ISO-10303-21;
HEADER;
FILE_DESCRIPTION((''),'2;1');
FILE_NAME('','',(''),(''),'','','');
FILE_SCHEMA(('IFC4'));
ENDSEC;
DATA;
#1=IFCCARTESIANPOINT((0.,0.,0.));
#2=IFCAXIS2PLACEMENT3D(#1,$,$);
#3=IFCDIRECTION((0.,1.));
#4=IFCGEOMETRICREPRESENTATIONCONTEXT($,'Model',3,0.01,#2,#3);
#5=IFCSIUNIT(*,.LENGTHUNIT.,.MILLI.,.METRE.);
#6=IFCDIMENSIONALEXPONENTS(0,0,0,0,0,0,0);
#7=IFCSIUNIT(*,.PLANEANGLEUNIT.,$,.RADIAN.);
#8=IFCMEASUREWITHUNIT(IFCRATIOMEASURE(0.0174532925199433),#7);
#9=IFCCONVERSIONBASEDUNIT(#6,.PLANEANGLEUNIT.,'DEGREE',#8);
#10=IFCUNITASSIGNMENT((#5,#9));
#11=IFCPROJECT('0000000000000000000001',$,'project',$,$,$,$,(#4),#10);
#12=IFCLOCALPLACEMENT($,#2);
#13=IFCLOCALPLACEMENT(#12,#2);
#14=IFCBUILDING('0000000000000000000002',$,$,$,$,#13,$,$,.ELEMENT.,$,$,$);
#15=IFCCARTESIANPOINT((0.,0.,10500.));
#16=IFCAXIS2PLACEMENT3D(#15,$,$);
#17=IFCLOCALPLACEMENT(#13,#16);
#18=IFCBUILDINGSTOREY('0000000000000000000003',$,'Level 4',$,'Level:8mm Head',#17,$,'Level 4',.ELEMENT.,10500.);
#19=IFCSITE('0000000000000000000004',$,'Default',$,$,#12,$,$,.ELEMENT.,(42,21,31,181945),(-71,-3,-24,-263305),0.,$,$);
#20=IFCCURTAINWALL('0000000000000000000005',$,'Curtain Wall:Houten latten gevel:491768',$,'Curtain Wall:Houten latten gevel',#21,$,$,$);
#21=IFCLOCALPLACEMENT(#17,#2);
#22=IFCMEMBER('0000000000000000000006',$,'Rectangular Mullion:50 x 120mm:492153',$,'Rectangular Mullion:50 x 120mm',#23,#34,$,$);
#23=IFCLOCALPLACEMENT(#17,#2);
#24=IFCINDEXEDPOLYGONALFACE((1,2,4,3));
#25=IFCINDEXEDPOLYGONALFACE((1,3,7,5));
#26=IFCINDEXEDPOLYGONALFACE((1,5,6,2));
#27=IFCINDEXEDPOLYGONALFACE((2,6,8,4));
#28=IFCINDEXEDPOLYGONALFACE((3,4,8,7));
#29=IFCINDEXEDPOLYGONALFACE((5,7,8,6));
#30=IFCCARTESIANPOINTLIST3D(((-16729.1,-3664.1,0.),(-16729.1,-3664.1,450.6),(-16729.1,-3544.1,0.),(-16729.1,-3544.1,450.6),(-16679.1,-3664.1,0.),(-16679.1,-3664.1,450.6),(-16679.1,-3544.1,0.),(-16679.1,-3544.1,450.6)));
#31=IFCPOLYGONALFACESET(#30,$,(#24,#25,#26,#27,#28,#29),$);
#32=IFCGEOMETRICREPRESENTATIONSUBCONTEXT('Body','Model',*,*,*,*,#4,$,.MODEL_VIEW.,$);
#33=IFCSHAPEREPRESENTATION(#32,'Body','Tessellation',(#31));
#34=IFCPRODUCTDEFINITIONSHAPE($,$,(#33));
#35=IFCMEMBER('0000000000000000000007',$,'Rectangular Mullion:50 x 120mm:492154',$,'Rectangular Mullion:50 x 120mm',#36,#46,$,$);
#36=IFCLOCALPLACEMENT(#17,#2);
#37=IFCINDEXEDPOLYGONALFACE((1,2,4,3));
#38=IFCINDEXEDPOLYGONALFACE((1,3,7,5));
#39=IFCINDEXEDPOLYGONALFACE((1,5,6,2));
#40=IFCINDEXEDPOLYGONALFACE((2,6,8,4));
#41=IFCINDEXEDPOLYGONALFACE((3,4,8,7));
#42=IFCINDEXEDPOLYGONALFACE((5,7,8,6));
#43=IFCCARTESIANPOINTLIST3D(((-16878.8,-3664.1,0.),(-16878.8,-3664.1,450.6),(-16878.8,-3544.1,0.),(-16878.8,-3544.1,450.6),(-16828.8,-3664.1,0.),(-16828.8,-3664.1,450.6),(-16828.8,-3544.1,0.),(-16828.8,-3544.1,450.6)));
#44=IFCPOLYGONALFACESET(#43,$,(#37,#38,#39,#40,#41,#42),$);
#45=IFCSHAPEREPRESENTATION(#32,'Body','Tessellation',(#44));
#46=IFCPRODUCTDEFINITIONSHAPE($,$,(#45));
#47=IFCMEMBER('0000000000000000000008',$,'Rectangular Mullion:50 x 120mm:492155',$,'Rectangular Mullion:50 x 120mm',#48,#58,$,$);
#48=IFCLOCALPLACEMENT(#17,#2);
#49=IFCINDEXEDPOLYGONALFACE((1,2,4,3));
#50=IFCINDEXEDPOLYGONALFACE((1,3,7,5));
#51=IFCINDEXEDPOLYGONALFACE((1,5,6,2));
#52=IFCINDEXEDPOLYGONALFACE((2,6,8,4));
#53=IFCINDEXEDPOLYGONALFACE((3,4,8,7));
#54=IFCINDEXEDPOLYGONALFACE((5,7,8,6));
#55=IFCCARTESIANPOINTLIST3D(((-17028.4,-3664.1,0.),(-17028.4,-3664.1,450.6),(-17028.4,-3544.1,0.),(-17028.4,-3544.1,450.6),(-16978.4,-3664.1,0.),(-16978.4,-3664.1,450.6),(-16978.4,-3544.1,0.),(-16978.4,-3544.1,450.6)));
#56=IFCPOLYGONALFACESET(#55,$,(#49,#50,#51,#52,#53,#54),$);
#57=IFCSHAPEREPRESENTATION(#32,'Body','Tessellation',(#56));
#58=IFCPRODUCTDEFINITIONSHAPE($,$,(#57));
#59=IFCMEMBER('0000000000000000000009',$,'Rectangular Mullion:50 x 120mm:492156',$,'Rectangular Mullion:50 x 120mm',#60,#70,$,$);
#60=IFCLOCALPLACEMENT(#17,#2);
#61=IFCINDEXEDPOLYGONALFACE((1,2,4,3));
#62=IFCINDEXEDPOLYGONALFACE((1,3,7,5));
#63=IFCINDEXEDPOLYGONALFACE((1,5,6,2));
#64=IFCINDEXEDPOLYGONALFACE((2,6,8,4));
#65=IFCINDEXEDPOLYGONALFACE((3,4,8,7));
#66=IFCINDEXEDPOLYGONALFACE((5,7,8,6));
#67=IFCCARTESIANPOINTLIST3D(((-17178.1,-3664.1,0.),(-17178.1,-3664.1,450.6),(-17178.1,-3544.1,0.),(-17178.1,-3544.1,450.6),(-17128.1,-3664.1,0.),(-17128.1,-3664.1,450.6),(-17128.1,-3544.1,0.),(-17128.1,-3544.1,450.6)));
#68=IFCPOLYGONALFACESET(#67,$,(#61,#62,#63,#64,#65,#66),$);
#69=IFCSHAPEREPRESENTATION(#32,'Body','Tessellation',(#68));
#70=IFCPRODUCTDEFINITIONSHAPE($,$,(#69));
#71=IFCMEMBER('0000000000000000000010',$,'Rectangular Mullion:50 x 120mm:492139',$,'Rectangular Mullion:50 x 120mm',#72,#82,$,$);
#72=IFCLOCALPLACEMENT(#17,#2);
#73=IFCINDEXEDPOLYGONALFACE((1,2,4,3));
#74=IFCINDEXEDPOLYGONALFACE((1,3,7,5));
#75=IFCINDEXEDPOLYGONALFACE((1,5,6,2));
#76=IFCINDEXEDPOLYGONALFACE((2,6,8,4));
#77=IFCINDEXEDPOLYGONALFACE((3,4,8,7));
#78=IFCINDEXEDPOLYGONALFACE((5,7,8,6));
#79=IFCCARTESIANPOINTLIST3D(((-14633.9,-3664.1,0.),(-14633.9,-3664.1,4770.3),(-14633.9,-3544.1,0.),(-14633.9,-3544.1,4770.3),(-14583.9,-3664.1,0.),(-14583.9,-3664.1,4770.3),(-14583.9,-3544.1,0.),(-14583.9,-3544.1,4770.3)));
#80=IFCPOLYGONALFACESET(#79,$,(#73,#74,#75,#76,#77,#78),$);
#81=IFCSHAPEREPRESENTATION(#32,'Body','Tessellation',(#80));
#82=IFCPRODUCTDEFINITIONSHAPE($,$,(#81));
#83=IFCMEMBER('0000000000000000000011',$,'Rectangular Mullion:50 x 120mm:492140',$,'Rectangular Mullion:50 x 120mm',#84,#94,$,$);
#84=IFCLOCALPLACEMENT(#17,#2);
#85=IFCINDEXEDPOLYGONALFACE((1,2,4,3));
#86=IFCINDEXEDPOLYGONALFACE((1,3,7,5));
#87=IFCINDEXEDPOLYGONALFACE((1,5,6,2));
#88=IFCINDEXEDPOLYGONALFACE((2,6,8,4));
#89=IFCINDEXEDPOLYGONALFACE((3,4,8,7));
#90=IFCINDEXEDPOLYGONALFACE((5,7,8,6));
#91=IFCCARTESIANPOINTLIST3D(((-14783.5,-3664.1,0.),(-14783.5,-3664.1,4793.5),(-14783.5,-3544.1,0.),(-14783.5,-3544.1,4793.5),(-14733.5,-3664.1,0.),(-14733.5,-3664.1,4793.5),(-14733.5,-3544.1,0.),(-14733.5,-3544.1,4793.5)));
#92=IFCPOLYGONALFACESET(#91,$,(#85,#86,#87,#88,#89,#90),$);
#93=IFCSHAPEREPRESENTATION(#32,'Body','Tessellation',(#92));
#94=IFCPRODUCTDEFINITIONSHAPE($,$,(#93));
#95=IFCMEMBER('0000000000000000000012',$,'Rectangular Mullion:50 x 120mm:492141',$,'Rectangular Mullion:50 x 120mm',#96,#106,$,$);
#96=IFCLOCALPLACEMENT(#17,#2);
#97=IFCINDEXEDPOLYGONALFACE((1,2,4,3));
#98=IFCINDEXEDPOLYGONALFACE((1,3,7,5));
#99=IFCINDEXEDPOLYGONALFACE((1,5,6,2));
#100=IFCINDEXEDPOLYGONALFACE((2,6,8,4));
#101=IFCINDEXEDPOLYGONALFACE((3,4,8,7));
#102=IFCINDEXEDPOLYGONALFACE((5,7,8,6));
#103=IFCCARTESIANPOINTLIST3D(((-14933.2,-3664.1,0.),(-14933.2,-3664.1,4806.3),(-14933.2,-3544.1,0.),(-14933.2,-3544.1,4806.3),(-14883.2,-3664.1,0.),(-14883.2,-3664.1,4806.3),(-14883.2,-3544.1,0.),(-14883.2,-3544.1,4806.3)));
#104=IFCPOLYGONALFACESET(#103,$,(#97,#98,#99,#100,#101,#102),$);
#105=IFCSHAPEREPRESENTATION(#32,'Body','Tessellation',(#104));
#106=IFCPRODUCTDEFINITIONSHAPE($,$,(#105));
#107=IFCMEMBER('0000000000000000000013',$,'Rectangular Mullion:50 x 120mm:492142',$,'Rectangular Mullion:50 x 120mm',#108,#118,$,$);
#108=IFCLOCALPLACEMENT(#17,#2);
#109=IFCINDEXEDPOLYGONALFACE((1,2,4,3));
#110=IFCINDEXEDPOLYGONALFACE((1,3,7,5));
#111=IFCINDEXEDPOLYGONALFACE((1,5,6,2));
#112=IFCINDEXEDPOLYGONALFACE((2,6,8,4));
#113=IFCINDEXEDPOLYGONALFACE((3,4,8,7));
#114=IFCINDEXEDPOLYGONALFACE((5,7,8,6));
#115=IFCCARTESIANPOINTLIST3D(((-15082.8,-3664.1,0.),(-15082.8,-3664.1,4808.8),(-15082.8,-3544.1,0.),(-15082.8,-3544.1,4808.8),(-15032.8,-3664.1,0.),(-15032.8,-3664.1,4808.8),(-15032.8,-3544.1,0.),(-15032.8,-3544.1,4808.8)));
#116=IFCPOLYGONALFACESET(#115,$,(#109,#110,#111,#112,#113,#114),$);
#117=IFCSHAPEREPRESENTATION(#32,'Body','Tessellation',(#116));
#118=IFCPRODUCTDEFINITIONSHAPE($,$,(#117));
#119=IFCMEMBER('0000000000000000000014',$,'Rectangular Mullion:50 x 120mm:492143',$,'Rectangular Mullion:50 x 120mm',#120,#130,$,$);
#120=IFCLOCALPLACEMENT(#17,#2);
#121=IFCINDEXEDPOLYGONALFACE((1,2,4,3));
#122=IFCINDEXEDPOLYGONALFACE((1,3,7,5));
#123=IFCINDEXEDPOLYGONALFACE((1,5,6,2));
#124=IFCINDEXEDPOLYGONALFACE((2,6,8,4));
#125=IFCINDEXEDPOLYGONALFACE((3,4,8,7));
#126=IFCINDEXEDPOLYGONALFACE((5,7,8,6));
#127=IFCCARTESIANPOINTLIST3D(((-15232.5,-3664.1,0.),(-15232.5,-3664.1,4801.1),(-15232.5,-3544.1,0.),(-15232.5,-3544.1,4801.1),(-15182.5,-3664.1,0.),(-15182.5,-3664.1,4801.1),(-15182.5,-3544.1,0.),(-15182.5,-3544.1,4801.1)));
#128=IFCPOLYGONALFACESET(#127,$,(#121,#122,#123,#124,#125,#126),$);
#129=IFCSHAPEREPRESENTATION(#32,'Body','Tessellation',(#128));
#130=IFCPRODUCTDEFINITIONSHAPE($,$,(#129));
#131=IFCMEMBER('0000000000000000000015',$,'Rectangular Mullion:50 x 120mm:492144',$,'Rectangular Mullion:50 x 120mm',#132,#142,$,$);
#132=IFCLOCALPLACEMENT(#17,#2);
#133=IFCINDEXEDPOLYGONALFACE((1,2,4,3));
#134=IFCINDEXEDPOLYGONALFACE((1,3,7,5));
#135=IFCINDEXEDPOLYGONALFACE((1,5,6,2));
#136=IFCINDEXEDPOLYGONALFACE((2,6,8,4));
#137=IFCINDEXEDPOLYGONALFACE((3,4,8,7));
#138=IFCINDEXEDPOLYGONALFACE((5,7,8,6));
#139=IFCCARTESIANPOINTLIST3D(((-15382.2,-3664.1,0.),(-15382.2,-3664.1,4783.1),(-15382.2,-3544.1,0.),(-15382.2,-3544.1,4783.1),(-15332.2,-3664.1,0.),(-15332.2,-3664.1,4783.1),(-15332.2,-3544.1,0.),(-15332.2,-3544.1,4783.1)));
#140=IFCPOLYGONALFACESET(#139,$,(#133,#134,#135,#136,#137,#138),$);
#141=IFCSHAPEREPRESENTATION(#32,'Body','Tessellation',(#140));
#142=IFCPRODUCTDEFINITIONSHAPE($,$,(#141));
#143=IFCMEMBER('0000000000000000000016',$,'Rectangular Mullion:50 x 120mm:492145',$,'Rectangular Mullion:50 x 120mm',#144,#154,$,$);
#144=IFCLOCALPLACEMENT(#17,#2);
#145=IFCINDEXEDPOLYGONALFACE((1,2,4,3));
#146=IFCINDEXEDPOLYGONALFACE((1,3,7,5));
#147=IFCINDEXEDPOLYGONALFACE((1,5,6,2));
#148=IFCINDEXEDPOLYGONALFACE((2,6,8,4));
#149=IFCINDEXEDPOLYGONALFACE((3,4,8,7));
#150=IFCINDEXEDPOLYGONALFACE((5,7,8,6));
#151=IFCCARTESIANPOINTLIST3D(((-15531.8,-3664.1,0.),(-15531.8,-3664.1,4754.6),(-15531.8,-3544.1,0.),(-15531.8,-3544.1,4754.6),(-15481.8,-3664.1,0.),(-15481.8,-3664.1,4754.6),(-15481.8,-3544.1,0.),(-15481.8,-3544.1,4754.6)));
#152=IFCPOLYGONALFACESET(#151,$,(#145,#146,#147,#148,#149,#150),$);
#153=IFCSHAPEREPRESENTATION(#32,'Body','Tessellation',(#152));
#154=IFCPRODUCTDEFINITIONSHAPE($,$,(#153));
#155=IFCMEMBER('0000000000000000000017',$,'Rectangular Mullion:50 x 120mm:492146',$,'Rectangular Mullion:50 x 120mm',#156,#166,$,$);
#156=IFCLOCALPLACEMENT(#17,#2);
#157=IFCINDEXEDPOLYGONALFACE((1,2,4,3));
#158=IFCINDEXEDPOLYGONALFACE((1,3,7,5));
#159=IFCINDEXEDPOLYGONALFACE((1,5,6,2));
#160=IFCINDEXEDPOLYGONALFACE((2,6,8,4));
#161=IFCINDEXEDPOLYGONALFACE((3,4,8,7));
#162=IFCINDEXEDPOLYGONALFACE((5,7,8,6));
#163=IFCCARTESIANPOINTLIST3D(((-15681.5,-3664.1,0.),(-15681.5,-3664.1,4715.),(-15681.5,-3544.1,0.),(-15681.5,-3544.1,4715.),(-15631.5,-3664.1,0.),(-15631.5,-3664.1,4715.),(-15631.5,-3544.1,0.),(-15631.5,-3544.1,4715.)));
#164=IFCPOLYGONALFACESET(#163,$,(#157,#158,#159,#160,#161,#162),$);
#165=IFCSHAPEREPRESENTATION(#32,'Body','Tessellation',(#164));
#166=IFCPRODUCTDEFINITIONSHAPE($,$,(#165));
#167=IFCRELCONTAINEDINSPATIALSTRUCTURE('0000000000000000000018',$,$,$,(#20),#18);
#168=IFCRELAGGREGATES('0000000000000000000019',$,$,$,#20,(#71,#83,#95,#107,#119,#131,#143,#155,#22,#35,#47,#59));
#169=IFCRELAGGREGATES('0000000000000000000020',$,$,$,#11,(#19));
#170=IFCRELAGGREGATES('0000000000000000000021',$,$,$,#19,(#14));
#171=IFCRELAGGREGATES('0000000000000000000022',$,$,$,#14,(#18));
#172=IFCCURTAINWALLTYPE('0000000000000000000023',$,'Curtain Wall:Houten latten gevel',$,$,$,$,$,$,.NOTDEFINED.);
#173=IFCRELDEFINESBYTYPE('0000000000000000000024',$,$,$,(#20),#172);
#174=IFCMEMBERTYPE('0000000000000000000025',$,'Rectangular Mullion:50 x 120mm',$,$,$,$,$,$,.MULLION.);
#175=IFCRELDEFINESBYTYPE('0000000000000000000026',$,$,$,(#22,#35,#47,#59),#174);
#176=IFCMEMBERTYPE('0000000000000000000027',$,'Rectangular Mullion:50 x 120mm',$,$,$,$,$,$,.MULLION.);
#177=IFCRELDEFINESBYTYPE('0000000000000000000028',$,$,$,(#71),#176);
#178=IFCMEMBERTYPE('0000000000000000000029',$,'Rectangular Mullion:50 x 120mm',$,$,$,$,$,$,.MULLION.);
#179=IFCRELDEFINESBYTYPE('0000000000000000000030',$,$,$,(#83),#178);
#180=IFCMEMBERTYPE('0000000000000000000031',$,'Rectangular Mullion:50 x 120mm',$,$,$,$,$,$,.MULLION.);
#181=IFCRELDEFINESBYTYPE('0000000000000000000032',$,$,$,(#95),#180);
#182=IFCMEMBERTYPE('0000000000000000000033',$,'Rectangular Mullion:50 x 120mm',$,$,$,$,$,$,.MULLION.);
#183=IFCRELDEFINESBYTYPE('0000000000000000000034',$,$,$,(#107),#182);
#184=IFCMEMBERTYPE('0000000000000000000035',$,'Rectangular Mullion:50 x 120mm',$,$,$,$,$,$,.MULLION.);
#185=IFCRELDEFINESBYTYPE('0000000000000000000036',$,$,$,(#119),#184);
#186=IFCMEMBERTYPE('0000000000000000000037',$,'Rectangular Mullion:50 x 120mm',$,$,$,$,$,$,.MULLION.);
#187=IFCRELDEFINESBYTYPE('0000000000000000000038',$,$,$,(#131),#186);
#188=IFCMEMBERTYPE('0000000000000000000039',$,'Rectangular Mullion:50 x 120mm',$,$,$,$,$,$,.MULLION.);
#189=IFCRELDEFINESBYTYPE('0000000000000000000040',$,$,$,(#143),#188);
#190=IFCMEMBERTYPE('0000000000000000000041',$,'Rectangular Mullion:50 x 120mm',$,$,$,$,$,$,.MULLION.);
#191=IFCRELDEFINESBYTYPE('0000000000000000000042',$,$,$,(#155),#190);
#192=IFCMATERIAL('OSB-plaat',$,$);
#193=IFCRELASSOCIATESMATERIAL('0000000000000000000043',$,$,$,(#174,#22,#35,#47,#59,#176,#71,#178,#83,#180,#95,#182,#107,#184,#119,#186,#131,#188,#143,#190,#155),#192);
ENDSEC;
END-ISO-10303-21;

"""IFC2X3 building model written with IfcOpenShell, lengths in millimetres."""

from ifc_helpers import new_model, entity, si_unit, converted_unit, direction, frame, origin, origin_2d_with_axis, place, context, subcontext, project, spatial, rectangle, extrude, source, transform, mapped, material, type_object, type_shapes, element, aggregate, save


model = new_model("IFC2X3")

# Units and contexts
model_context = context("Model", 3, precision=0.01, world=origin(), true_north=direction((0.0, 1.0)))
body_context = subcontext(model_context, "Body", "Model", "MODEL_VIEW")
ifc_project = project(units=[si_unit("LENGTHUNIT", "METRE", prefix="MILLI"), converted_unit("PLANEANGLEUNIT", "DEGREE", entity("IfcRatioMeasure", 0.0174532925199433), si_unit("PLANEANGLEUNIT", "RADIAN"), dimensions=[0, 0, 0, 0, 0, 0, 0])], contexts=[model_context])

# Site, building, storey
site_placement = place(None, frame((0.0, 0.0, 0.0)))
site = spatial("IfcSite", under=ifc_project, at=site_placement, Name="Default", CompositionType="ELEMENT", RefLatitude=(42, 21, 31, 181945), RefLongitude=(-71, -3, -24, -263305), RefElevation=0.0)
building_placement = place(site_placement, origin())
building = spatial("IfcBuilding", under=site, at=building_placement, CompositionType="ELEMENT")
storey_placement = place(building_placement, frame((0.0, 0.0, 10500.0)))
storey = spatial("IfcBuildingStorey", under=building, at=storey_placement, Name="Level 4", ObjectType="Level:8mm Head", LongName="Level 4", CompositionType="ELEMENT", Elevation=10500.0)

# Curtain wall, members
curtain_wall_type = type_object("IfcCurtainWallType", Name="Curtain Wall:Houten latten gevel", PredefinedType="NOTDEFINED")
curtain_wall_placement = place(storey_placement, frame((0.0, 0.0, -10500.0)))
curtain_wall = element("IfcCurtainWall", 1, at=curtain_wall_placement, inside=storey, type_object=curtain_wall_type, Name="Curtain Wall:Houten latten gevel:491768", ObjectType="Curtain Wall:Houten latten gevel")
ifc_material_1 = material(Name="OSB-plaat")
member_type_1 = type_object("IfcMemberType", Name="Rectangular Mullion:50 x 120mm", PredefinedType="MULLION", material=ifc_material_1)
shared_shape_1 = source(origin(), body_context, "Body", "SweptSolid", [
    extrude(rectangle(XDim=120.0, YDim=50.0, at=origin_2d_with_axis()), frame((0.0, 0.0, -450.6), z_axis=(0.0, 0.0, 1.0), x_axis=(0.0, -1.0, 0.0)), (0.0, 0.0, 1.0), 450.6),
])
type_shapes(member_type_1, [shared_shape_1])
placement = place(building_placement, frame((0.0, 0.0, 7500.0)))
member_1_placement = place(placement, frame((-16704.1, -3604.1, 3000.0), z_axis=(0.0, 0.0, -1.0), x_axis=(-1.0, 0.0, 0.0)))
member_1 = element("IfcMember", 2, at=member_1_placement, type_object=member_type_1, material=ifc_material_1, Name="Rectangular Mullion:50 x 120mm:492153", ObjectType="Rectangular Mullion:50 x 120mm", context=body_context, shape_type="MappedRepresentation", body=[
    mapped(shared_shape_1, transform((0.0, 0.0, 0.0), scale=1.0)),
])
member_2_placement = place(placement, frame((-16853.8, -3604.1, 3000.0), z_axis=(0.0, 0.0, -1.0), x_axis=(-1.0, 0.0, 0.0)))
member_2 = element("IfcMember", 3, at=member_2_placement, type_object=member_type_1, material=ifc_material_1, Name="Rectangular Mullion:50 x 120mm:492154", ObjectType="Rectangular Mullion:50 x 120mm", context=body_context, shape_type="MappedRepresentation", body=[
    mapped(shared_shape_1, transform((0.0, 0.0, 0.0), scale=1.0)),
])
member_3_placement = place(placement, frame((-17003.4, -3604.1, 3000.0), z_axis=(0.0, 0.0, -1.0), x_axis=(-1.0, 0.0, 0.0)))
member_3 = element("IfcMember", 4, at=member_3_placement, type_object=member_type_1, material=ifc_material_1, Name="Rectangular Mullion:50 x 120mm:492155", ObjectType="Rectangular Mullion:50 x 120mm", context=body_context, shape_type="MappedRepresentation", body=[
    mapped(shared_shape_1, transform((0.0, 0.0, 0.0), scale=1.0)),
])
member_4_placement = place(placement, frame((-17153.1, -3604.1, 3000.0), z_axis=(0.0, 0.0, -1.0), x_axis=(-1.0, 0.0, 0.0)))
member_4 = element("IfcMember", 5, at=member_4_placement, type_object=member_type_1, material=ifc_material_1, Name="Rectangular Mullion:50 x 120mm:492156", ObjectType="Rectangular Mullion:50 x 120mm", context=body_context, shape_type="MappedRepresentation", body=[
    mapped(shared_shape_1, transform((0.0, 0.0, 0.0), scale=1.0)),
])
member_type_2 = type_object("IfcMemberType", Name="Rectangular Mullion:50 x 120mm", PredefinedType="MULLION", material=ifc_material_1)
shared_shape_2 = source(origin(), body_context, "Body", "SweptSolid", [
    extrude(rectangle(XDim=120.0, YDim=50.0, at=origin_2d_with_axis()), frame((0.0, 0.0, -4770.3), z_axis=(0.0, 0.0, 1.0), x_axis=(0.0, -1.0, 0.0)), (0.0, 0.0, 1.0), 4770.3),
])
type_shapes(member_type_2, [shared_shape_2])
member_5_placement = place(placement, frame((-14608.9, -3604.1, 3000.0), z_axis=(0.0, 0.0, -1.0), x_axis=(-1.0, 0.0, 0.0)))
member_5 = element("IfcMember", 6, at=member_5_placement, type_object=member_type_2, material=ifc_material_1, Name="Rectangular Mullion:50 x 120mm:492139", ObjectType="Rectangular Mullion:50 x 120mm", context=body_context, shape_type="MappedRepresentation", body=[
    mapped(shared_shape_2, transform((0.0, 0.0, 0.0), scale=1.0)),
])
member_type_3 = type_object("IfcMemberType", Name="Rectangular Mullion:50 x 120mm", PredefinedType="MULLION", material=ifc_material_1)
shared_shape_3 = source(origin(), body_context, "Body", "SweptSolid", [
    extrude(rectangle(XDim=120.0, YDim=50.0, at=origin_2d_with_axis()), frame((0.0, 0.0, -4793.5), z_axis=(0.0, 0.0, 1.0), x_axis=(0.0, -1.0, 0.0)), (0.0, 0.0, 1.0), 4793.5),
])
type_shapes(member_type_3, [shared_shape_3])
member_6_placement = place(placement, frame((-14758.5, -3604.1, 3000.0), z_axis=(0.0, 0.0, -1.0), x_axis=(-1.0, 0.0, 0.0)))
member_6 = element("IfcMember", 7, at=member_6_placement, type_object=member_type_3, material=ifc_material_1, Name="Rectangular Mullion:50 x 120mm:492140", ObjectType="Rectangular Mullion:50 x 120mm", context=body_context, shape_type="MappedRepresentation", body=[
    mapped(shared_shape_3, transform((0.0, 0.0, 0.0), scale=1.0)),
])
member_type_4 = type_object("IfcMemberType", Name="Rectangular Mullion:50 x 120mm", PredefinedType="MULLION", material=ifc_material_1)
shared_shape_4 = source(origin(), body_context, "Body", "SweptSolid", [
    extrude(rectangle(XDim=120.0, YDim=50.0, at=origin_2d_with_axis()), frame((0.0, 0.0, -4806.3), z_axis=(0.0, 0.0, 1.0), x_axis=(0.0, -1.0, 0.0)), (0.0, 0.0, 1.0), 4806.3),
])
type_shapes(member_type_4, [shared_shape_4])
member_7_placement = place(placement, frame((-14908.2, -3604.1, 3000.0), z_axis=(0.0, 0.0, -1.0), x_axis=(-1.0, 0.0, 0.0)))
member_7 = element("IfcMember", 8, at=member_7_placement, type_object=member_type_4, material=ifc_material_1, Name="Rectangular Mullion:50 x 120mm:492141", ObjectType="Rectangular Mullion:50 x 120mm", context=body_context, shape_type="MappedRepresentation", body=[
    mapped(shared_shape_4, transform((0.0, 0.0, 0.0), scale=1.0)),
])
member_type_5 = type_object("IfcMemberType", Name="Rectangular Mullion:50 x 120mm", PredefinedType="MULLION", material=ifc_material_1)
shared_shape_5 = source(origin(), body_context, "Body", "SweptSolid", [
    extrude(rectangle(XDim=120.0, YDim=50.0, at=origin_2d_with_axis()), frame((0.0, 0.0, -4808.8), z_axis=(0.0, 0.0, 1.0), x_axis=(0.0, -1.0, 0.0)), (0.0, 0.0, 1.0), 4808.8),
])
type_shapes(member_type_5, [shared_shape_5])
member_8_placement = place(placement, frame((-15057.8, -3604.1, 3000.0), z_axis=(0.0, 0.0, -1.0), x_axis=(-1.0, 0.0, 0.0)))
member_8 = element("IfcMember", 9, at=member_8_placement, type_object=member_type_5, material=ifc_material_1, Name="Rectangular Mullion:50 x 120mm:492142", ObjectType="Rectangular Mullion:50 x 120mm", context=body_context, shape_type="MappedRepresentation", body=[
    mapped(shared_shape_5, transform((0.0, 0.0, 0.0), scale=1.0)),
])
member_type_6 = type_object("IfcMemberType", Name="Rectangular Mullion:50 x 120mm", PredefinedType="MULLION", material=ifc_material_1)
shared_shape_6 = source(origin(), body_context, "Body", "SweptSolid", [
    extrude(rectangle(XDim=120.0, YDim=50.0, at=origin_2d_with_axis()), frame((0.0, 0.0, -4801.1), z_axis=(0.0, 0.0, 1.0), x_axis=(0.0, -1.0, 0.0)), (0.0, 0.0, 1.0), 4801.1),
])
type_shapes(member_type_6, [shared_shape_6])
member_9_placement = place(placement, frame((-15207.5, -3604.1, 3000.0), z_axis=(0.0, 0.0, -1.0), x_axis=(-1.0, 0.0, 0.0)))
member_9 = element("IfcMember", 10, at=member_9_placement, type_object=member_type_6, material=ifc_material_1, Name="Rectangular Mullion:50 x 120mm:492143", ObjectType="Rectangular Mullion:50 x 120mm", context=body_context, shape_type="MappedRepresentation", body=[
    mapped(shared_shape_6, transform((0.0, 0.0, 0.0), scale=1.0)),
])
member_type_7 = type_object("IfcMemberType", Name="Rectangular Mullion:50 x 120mm", PredefinedType="MULLION", material=ifc_material_1)
shared_shape_7 = source(origin(), body_context, "Body", "SweptSolid", [
    extrude(rectangle(XDim=120.0, YDim=50.0, at=origin_2d_with_axis()), frame((0.0, 0.0, -4783.1), z_axis=(0.0, 0.0, 1.0), x_axis=(0.0, -1.0, 0.0)), (0.0, 0.0, 1.0), 4783.1),
])
type_shapes(member_type_7, [shared_shape_7])
member_10_placement = place(placement, frame((-15357.2, -3604.1, 3000.0), z_axis=(0.0, 0.0, -1.0), x_axis=(-1.0, 0.0, 0.0)))
member_10 = element("IfcMember", 11, at=member_10_placement, type_object=member_type_7, material=ifc_material_1, Name="Rectangular Mullion:50 x 120mm:492144", ObjectType="Rectangular Mullion:50 x 120mm", context=body_context, shape_type="MappedRepresentation", body=[
    mapped(shared_shape_7, transform((0.0, 0.0, 0.0), scale=1.0)),
])
member_type_8 = type_object("IfcMemberType", Name="Rectangular Mullion:50 x 120mm", PredefinedType="MULLION", material=ifc_material_1)
shared_shape_8 = source(origin(), body_context, "Body", "SweptSolid", [
    extrude(rectangle(XDim=120.0, YDim=50.0, at=origin_2d_with_axis()), frame((0.0, 0.0, -4754.6), z_axis=(0.0, 0.0, 1.0), x_axis=(0.0, -1.0, 0.0)), (0.0, 0.0, 1.0), 4754.6),
])
type_shapes(member_type_8, [shared_shape_8])
member_11_placement = place(placement, frame((-15506.8, -3604.1, 3000.0), z_axis=(0.0, 0.0, -1.0), x_axis=(-1.0, 0.0, 0.0)))
member_11 = element("IfcMember", 12, at=member_11_placement, type_object=member_type_8, material=ifc_material_1, Name="Rectangular Mullion:50 x 120mm:492145", ObjectType="Rectangular Mullion:50 x 120mm", context=body_context, shape_type="MappedRepresentation", body=[
    mapped(shared_shape_8, transform((0.0, 0.0, 0.0), scale=1.0)),
])
member_type_9 = type_object("IfcMemberType", Name="Rectangular Mullion:50 x 120mm", PredefinedType="MULLION", material=ifc_material_1)
shared_shape_9 = source(origin(), body_context, "Body", "SweptSolid", [
    extrude(rectangle(XDim=120.0, YDim=50.0, at=origin_2d_with_axis()), frame((0.0, 0.0, -4715.0), z_axis=(0.0, 0.0, 1.0), x_axis=(0.0, -1.0, 0.0)), (0.0, 0.0, 1.0), 4715.0),
])
type_shapes(member_type_9, [shared_shape_9])
member_12_placement = place(placement, frame((-15656.5, -3604.1, 3000.0), z_axis=(0.0, 0.0, -1.0), x_axis=(-1.0, 0.0, 0.0)))
member_12 = element("IfcMember", 13, at=member_12_placement, type_object=member_type_9, material=ifc_material_1, Name="Rectangular Mullion:50 x 120mm:492146", ObjectType="Rectangular Mullion:50 x 120mm", context=body_context, shape_type="MappedRepresentation", body=[
    mapped(shared_shape_9, transform((0.0, 0.0, 0.0), scale=1.0)),
])
aggregate(curtain_wall, [member_5, member_6, member_7, member_8, member_9, member_10, member_11, member_12, member_1, member_2, member_3, member_4])

save(model, "model.ifc")
